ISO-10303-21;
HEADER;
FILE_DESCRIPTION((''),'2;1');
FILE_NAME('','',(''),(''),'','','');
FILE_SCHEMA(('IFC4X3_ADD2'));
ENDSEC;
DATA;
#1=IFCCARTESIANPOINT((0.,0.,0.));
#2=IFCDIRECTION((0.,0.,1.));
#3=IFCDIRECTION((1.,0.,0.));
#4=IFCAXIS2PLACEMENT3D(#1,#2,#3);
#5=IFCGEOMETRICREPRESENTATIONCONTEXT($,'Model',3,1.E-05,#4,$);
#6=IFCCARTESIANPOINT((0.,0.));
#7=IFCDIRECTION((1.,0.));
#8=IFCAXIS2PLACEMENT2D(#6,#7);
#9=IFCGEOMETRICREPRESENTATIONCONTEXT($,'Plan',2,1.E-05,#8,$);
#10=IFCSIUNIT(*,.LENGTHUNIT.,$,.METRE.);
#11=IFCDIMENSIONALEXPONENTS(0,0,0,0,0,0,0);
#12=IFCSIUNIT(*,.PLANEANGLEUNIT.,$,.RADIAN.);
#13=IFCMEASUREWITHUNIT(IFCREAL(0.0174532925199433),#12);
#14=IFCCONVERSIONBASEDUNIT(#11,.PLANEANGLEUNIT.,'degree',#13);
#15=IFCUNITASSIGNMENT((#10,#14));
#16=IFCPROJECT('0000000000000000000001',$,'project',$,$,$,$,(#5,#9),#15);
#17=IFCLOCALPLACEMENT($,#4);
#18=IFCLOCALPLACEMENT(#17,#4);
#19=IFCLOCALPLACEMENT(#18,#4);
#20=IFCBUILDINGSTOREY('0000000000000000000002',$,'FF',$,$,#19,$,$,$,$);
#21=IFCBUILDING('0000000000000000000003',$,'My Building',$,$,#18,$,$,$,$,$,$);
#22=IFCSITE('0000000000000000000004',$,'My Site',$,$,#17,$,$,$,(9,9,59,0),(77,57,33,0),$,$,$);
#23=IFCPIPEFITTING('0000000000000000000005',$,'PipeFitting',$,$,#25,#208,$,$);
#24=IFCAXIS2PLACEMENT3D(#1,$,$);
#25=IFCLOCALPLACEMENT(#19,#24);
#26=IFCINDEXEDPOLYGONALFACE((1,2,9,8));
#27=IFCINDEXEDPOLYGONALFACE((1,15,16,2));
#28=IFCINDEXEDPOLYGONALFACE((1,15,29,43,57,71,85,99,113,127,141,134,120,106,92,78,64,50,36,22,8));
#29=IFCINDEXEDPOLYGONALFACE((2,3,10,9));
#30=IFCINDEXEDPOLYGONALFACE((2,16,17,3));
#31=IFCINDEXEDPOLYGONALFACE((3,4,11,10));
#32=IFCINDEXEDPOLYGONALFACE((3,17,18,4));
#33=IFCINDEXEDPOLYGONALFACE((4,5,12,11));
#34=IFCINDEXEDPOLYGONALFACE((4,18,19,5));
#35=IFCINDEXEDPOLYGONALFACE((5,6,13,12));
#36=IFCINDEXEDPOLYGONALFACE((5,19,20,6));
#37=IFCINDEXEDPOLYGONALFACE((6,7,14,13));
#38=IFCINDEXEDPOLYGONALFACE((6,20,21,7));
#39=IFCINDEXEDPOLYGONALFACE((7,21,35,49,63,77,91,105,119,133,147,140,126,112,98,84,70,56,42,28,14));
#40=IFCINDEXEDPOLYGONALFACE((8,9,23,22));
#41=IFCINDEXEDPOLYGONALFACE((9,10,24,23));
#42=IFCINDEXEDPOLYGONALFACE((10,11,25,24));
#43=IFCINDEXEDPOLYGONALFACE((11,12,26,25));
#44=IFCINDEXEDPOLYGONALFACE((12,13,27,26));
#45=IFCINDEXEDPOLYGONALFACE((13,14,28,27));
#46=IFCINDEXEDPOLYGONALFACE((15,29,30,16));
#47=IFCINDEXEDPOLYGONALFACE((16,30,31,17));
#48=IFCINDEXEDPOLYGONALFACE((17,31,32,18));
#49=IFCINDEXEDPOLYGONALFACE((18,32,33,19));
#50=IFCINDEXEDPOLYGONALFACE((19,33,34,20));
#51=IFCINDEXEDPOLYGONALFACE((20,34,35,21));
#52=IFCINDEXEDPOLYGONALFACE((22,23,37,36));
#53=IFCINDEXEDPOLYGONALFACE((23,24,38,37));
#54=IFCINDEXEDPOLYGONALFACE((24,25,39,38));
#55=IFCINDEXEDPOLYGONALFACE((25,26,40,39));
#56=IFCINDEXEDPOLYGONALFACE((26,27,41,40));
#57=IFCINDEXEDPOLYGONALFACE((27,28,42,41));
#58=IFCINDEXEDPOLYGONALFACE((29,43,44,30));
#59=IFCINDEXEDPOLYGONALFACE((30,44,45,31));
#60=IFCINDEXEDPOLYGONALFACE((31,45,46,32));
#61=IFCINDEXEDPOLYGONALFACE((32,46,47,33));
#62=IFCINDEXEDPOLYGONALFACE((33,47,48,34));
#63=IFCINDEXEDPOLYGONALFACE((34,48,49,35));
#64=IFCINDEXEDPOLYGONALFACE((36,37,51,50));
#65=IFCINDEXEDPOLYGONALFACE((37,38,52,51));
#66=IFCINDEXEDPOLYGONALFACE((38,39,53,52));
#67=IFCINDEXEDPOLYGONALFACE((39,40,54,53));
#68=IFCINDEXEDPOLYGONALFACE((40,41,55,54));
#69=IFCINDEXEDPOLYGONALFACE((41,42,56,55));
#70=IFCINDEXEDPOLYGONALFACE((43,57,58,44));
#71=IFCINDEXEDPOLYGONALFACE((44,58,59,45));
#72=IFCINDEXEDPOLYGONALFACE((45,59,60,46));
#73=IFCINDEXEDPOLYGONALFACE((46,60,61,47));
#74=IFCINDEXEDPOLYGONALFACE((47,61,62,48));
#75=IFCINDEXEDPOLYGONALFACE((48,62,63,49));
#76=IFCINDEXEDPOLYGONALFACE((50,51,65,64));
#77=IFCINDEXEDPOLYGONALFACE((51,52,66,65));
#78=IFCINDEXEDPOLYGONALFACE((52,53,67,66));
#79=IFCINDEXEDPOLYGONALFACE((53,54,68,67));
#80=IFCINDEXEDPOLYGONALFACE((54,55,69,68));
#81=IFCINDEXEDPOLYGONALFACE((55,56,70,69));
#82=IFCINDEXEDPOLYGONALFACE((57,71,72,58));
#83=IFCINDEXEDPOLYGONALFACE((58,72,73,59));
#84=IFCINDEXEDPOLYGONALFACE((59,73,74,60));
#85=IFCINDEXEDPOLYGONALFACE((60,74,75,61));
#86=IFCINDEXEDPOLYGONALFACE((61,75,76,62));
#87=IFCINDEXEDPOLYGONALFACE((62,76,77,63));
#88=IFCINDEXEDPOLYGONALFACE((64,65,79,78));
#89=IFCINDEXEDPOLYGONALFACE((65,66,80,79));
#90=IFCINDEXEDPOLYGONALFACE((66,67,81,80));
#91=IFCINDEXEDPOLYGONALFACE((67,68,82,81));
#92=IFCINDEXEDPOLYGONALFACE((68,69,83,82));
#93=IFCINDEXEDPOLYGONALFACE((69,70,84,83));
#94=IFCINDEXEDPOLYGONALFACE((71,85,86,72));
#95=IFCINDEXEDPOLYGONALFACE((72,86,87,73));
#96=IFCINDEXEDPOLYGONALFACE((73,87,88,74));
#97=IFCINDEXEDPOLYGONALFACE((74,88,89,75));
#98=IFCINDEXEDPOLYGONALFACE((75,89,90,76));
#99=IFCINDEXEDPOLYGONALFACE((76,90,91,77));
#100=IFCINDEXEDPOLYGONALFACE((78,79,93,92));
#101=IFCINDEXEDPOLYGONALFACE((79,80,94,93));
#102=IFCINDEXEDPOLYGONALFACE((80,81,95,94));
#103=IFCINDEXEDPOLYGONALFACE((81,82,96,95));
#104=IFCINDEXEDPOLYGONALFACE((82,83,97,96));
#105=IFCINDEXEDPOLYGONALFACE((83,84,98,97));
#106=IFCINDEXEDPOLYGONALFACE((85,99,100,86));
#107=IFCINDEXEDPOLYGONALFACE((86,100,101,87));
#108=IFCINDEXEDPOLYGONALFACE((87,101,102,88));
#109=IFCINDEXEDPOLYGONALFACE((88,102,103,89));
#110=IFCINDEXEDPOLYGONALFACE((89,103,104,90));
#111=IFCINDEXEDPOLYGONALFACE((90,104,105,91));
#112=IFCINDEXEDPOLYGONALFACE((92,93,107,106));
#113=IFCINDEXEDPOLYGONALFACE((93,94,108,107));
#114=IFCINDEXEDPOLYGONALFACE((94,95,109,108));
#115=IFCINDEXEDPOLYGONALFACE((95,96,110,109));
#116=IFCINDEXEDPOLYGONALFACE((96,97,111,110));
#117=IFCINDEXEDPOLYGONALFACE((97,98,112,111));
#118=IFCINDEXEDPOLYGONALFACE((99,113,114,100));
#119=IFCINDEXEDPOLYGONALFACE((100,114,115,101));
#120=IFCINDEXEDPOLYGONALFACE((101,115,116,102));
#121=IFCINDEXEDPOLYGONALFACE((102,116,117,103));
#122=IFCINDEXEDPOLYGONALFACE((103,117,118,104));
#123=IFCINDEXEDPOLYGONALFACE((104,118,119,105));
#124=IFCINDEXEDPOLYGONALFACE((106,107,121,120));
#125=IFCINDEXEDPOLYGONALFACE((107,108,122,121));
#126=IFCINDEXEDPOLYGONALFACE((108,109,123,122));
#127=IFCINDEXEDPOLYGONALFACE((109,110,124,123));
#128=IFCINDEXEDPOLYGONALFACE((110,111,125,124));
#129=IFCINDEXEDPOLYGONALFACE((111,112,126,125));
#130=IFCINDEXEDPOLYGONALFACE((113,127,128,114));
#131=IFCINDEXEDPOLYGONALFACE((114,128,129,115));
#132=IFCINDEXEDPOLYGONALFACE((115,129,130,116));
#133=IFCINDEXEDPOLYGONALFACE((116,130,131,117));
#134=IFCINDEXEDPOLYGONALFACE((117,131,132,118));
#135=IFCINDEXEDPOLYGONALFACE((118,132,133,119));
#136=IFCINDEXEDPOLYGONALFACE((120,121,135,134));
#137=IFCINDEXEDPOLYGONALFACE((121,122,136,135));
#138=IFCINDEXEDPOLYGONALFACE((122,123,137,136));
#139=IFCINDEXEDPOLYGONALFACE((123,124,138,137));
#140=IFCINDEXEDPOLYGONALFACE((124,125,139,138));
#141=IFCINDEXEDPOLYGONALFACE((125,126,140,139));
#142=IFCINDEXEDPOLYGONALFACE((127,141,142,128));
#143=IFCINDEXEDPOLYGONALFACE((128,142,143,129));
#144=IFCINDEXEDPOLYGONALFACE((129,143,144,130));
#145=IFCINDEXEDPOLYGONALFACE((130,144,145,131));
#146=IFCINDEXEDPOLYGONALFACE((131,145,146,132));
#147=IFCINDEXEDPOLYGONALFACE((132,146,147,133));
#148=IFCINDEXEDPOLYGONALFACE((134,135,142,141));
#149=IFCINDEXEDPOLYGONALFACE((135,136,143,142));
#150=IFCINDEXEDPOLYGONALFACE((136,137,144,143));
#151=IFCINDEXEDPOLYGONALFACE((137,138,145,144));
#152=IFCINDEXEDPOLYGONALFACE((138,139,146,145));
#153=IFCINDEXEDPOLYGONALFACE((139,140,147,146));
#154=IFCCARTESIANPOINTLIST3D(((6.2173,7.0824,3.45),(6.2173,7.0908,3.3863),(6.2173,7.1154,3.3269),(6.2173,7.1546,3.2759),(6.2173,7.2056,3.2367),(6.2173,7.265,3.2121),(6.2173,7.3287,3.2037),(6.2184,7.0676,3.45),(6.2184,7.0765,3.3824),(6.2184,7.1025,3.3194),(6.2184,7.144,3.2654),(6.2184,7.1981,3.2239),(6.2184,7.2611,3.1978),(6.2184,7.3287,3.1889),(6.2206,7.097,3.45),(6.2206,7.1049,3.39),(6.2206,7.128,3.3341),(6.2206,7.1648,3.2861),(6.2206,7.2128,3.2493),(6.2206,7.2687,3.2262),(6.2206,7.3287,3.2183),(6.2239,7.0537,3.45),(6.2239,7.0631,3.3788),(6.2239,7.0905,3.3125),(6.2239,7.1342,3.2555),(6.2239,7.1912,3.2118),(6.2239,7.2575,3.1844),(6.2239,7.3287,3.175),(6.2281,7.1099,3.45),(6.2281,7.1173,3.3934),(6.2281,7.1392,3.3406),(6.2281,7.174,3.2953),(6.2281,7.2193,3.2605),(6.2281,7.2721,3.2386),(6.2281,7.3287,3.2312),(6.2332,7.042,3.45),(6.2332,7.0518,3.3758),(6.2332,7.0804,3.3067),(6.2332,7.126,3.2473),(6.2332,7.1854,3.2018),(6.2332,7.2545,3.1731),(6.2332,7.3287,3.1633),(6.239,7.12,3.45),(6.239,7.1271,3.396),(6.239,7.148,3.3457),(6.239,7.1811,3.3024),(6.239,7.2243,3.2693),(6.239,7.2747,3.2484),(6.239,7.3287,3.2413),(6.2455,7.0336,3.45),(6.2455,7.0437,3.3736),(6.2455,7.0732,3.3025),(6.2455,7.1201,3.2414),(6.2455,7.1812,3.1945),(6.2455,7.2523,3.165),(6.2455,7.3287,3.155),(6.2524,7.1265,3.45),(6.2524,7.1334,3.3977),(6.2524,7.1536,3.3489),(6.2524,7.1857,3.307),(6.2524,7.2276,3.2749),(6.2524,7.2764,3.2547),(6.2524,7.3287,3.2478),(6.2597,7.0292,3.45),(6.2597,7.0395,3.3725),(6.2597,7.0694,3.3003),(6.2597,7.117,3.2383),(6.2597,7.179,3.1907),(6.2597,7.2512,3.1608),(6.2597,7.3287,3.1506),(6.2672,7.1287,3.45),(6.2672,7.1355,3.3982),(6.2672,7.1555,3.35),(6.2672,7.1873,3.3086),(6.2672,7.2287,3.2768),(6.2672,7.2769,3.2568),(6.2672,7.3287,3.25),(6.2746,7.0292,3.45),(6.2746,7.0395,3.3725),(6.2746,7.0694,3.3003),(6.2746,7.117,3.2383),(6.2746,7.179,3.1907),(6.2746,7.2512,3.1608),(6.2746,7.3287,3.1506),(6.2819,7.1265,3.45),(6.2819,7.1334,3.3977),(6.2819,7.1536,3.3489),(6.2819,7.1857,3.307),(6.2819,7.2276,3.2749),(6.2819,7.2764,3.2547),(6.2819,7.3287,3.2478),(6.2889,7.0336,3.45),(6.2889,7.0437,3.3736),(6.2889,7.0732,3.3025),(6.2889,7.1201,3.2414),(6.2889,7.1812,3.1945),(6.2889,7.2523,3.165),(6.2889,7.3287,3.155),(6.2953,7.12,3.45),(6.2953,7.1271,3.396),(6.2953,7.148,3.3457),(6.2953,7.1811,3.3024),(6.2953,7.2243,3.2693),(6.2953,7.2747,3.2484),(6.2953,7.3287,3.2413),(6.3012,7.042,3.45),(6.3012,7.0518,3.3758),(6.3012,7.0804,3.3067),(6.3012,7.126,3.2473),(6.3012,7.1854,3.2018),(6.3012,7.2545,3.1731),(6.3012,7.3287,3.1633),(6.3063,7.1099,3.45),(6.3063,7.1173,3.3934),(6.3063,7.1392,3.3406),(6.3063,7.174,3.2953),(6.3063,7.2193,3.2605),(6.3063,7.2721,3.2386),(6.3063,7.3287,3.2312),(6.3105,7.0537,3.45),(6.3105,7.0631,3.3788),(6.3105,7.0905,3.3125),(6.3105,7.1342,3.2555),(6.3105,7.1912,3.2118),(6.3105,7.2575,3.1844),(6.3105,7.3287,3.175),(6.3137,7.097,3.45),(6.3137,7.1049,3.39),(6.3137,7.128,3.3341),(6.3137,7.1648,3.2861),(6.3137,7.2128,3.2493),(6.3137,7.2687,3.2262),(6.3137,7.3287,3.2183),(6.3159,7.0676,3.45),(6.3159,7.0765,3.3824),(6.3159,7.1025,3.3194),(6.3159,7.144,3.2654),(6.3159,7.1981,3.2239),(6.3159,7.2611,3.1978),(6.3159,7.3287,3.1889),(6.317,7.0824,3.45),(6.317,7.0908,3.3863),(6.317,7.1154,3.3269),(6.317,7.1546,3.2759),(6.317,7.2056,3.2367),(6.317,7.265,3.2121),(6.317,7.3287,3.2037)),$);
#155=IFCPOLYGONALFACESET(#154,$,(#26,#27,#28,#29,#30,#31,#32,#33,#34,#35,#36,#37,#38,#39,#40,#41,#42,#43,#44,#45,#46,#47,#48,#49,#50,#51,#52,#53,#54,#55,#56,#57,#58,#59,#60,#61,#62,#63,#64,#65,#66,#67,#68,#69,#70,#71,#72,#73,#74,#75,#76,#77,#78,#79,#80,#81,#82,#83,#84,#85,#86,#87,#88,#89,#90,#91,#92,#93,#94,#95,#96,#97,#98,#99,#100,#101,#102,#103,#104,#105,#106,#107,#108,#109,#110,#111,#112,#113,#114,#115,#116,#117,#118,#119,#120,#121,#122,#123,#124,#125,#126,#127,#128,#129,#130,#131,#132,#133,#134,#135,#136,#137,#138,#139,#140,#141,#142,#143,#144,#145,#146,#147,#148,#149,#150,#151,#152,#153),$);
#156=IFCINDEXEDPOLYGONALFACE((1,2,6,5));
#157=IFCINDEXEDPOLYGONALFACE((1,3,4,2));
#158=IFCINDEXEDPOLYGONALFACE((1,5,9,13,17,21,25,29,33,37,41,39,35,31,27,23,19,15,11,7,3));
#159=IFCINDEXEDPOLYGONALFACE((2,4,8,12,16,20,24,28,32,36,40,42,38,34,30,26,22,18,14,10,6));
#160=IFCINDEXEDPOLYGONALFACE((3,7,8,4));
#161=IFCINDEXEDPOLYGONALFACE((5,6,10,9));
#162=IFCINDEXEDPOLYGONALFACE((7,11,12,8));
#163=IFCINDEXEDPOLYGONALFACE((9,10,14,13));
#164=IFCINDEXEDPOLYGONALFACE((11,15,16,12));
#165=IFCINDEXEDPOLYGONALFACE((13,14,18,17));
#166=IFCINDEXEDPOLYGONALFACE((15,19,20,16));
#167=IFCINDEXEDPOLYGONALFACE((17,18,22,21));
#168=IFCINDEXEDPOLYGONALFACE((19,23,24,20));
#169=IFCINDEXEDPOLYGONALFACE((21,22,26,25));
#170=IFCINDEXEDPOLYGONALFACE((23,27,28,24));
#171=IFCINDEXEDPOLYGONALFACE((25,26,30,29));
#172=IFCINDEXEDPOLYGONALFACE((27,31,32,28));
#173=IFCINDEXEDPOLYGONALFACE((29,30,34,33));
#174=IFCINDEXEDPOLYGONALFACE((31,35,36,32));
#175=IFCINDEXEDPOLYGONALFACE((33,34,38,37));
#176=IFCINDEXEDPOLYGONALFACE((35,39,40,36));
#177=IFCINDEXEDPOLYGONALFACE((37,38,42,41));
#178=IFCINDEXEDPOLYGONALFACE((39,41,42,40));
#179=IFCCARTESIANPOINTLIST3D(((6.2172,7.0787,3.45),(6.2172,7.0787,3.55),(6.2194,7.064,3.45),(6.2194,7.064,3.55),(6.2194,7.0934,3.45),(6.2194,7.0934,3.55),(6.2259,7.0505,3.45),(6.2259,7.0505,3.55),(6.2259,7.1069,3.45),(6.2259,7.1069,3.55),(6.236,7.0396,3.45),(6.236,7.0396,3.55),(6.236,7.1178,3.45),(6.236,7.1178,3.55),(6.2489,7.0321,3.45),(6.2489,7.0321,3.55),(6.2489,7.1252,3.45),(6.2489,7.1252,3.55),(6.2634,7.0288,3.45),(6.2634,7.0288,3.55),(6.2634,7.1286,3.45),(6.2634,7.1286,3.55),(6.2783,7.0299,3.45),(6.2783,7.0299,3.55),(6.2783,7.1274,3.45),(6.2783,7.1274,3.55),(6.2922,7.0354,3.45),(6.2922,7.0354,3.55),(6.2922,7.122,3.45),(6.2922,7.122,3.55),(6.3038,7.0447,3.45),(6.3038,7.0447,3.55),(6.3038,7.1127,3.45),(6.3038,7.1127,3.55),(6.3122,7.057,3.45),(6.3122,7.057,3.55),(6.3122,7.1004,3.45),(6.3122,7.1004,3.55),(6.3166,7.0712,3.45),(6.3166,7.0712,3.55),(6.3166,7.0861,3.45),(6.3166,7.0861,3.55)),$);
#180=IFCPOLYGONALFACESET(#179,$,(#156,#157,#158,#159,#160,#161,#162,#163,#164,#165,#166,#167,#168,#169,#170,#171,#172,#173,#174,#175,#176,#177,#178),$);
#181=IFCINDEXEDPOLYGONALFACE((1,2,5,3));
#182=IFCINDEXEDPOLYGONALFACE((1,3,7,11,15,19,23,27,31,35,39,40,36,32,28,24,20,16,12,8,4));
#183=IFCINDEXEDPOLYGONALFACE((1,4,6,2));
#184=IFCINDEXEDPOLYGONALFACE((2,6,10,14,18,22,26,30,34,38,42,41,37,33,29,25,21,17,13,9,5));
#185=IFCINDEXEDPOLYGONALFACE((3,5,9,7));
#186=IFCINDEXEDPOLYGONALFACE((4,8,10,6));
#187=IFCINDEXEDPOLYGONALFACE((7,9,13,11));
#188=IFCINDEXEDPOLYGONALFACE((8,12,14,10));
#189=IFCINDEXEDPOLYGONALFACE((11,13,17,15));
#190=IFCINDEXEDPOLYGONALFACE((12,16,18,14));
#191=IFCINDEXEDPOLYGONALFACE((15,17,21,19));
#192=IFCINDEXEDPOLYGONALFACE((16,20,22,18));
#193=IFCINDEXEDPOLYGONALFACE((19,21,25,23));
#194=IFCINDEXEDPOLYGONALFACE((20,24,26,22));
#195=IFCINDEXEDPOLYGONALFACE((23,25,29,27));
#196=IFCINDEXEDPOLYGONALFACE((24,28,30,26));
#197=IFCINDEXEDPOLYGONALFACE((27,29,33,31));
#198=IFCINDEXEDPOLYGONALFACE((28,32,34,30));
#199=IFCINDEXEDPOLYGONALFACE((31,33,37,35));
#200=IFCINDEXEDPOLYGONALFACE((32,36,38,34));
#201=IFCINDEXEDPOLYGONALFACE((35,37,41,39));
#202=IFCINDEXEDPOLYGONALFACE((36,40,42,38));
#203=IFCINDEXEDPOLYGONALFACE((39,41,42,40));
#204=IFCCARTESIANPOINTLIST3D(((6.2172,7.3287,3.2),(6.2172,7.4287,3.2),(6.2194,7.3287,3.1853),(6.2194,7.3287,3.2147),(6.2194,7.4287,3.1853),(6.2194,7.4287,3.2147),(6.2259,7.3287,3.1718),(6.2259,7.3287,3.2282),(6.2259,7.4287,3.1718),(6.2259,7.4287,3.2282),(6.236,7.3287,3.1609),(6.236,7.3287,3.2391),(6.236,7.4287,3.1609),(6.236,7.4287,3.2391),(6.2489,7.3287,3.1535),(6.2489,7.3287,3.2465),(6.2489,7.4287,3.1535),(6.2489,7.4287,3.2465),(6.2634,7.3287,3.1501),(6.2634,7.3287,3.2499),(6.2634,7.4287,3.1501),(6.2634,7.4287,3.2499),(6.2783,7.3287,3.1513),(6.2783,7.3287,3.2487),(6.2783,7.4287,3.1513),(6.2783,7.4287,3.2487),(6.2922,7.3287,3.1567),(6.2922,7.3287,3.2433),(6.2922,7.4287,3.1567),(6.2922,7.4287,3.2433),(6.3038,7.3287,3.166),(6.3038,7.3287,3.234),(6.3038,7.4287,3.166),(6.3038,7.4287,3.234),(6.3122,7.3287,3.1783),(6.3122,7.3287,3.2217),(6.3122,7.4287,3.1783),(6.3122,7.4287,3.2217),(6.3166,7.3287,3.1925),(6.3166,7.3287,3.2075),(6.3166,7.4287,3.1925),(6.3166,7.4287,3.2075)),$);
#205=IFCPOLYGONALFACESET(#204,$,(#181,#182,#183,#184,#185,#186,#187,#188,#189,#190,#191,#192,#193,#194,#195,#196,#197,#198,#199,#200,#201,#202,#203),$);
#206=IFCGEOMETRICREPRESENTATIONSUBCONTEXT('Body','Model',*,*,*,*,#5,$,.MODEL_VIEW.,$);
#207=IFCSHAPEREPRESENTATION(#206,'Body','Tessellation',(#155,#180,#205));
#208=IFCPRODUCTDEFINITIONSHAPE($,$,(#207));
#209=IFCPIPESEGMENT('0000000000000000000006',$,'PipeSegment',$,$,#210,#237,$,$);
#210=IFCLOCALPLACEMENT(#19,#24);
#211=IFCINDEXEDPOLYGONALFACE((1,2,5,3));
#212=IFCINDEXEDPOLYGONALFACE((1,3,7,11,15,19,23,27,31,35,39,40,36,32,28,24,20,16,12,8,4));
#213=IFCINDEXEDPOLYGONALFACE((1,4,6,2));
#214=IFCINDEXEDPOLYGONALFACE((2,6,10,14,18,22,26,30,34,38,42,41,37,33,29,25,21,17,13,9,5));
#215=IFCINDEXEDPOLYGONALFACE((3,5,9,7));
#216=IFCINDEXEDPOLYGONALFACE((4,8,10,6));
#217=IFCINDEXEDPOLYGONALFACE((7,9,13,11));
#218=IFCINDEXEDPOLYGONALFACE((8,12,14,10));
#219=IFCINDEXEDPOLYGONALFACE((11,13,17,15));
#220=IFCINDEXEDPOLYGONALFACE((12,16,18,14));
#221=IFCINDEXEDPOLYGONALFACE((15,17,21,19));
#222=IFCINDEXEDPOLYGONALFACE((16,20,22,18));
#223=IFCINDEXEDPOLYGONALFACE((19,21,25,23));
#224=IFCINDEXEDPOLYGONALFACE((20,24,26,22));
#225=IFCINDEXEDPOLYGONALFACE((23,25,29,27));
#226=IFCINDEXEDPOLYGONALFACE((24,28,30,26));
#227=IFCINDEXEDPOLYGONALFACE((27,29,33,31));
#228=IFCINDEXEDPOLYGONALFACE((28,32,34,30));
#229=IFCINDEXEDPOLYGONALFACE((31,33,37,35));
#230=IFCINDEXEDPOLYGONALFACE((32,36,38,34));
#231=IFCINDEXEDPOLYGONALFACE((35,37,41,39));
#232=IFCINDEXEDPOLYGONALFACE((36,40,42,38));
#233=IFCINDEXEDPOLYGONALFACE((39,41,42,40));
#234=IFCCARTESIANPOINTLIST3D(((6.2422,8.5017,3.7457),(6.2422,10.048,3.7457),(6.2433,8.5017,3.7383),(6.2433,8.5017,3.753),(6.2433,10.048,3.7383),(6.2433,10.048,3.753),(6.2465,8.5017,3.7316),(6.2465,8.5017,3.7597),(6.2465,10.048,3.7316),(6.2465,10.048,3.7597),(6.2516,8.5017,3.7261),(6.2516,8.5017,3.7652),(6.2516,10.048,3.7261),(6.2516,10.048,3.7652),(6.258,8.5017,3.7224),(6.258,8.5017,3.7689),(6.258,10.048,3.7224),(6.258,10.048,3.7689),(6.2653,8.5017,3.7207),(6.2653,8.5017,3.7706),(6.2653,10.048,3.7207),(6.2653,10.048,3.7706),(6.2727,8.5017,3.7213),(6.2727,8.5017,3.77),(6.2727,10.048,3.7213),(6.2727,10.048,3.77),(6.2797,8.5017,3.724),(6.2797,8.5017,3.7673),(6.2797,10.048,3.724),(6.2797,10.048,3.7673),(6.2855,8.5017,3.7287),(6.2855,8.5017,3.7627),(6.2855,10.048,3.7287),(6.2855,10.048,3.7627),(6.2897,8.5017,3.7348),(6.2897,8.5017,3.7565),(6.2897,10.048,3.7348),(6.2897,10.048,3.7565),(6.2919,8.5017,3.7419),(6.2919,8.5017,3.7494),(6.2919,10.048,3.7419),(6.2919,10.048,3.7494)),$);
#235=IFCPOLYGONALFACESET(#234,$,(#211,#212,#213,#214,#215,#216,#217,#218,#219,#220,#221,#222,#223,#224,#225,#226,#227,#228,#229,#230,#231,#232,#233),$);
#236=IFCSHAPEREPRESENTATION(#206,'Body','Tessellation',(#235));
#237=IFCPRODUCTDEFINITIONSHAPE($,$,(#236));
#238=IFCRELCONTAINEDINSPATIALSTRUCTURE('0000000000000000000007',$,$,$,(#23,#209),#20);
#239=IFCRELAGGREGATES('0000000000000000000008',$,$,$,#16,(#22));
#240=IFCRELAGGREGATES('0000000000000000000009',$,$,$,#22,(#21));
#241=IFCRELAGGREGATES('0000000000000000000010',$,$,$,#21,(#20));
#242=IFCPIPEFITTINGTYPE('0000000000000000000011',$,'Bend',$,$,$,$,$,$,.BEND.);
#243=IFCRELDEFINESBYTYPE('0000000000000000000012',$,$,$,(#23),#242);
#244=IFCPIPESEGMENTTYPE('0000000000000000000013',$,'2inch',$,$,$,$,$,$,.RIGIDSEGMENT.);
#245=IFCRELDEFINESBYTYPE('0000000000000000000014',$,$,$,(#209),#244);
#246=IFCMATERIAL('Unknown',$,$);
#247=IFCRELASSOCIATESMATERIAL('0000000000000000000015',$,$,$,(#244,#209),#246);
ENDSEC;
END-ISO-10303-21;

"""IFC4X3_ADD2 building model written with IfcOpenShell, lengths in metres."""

from ifc_helpers import new_model, entity, si_unit, converted_unit, frame, origin_with_axes, origin_2d_with_axis, place, context, subcontext, project, spatial, circle, extrude, source, transform, mapped, material, material_profile, profile_set, profile_usage, type_object, type_shapes, element, save


model = new_model("IFC4X3_ADD2")

# Units and contexts
model_context = context("Model", 3, precision=1e-05, world=origin_with_axes())
plan_context = context("Plan", 2, precision=1e-05, world=origin_2d_with_axis())
body_context_1 = subcontext(model_context, "Body", "Model", "MODEL_VIEW")
ifc_project = project(units=[si_unit("LENGTHUNIT", "METRE"), converted_unit("PLANEANGLEUNIT", "degree", entity("IfcReal", 0.0174532925199433), si_unit("PLANEANGLEUNIT", "RADIAN"), dimensions=[0, 0, 0, 0, 0, 0, 0])], contexts=[model_context, plan_context])

# Site, building, storey
site_placement = place(None, origin_with_axes())
site = spatial("IfcSite", under=ifc_project, at=site_placement, Name="My Site", RefLatitude=(9, 9, 59, 0), RefLongitude=(77, 57, 33, 0))
building_placement = place(site_placement, origin_with_axes())
building = spatial("IfcBuilding", under=site, at=building_placement, Name="My Building")
storey_placement = place(building_placement, origin_with_axes())
storey = spatial("IfcBuildingStorey", under=building, at=storey_placement, Name="FF")

# Shared definitions
ifc_material = material(Name="Unknown")

# Pipe fitting
pipe_fitting_type_1 = type_object("IfcPipeFittingType", Name="Bend", PredefinedType="BEND")
shared_shape_1 = source(origin_with_axes(), body_context_1, "Body", "SolidModel", [
    entity("IfcSweptDiskSolid", entity("IfcIndexedPolyCurve", entity("IfcCartesianPointList3D", [[0.0, 0.0, -0.1], [0.0, -0.0732, -0.2768], [0.0, -0.25, -0.35]]), [entity("IfcArcIndex", [1, 2, 3])]), 0.05),
    extrude(circle(Radius=0.05), origin_with_axes(), (0.0, 0.0, -1.0), 0.1),
    extrude(circle(Radius=0.05), frame((0.0, -0.25, -0.35), z_axis=(0.0, -1.0, 0.0), x_axis=(1.0, 0.0, 0.0)), (0.0, 0.0, 1.0), 0.1),
])
type_shapes(pipe_fitting_type_1, [shared_shape_1])
pipe_fitting_1_placement = place(storey_placement, frame((6.2672, 7.0787, 3.55), z_axis=(0.0, 0.0, 1.0), x_axis=(-1.0, 0.0, 0.0)))
element("IfcPipeFitting", 1, at=pipe_fitting_1_placement, inside=storey, type_object=pipe_fitting_type_1, Name="PipeFitting", context=body_context_1, shape_type="MappedRepresentation", body=[
    mapped(shared_shape_1, transform((0.0, 0.0, 0.0), x_axis=(1.0, 0.0, 0.0), y_axis=(0.0, 1.0, 0.0), z_axis=(0.0, 0.0, 1.0), scale=1.0)),
])

# Pipe segment
ifc_material_profile_1 = material_profile(ifc_material, circle(Radius=0.025))
ifc_profile_set_1 = profile_set([ifc_material_profile_1])
ifc_profile_usage_1 = profile_usage(ifc_profile_set_1)
pipe_segment_type_1 = type_object("IfcPipeSegmentType", Name="2inch", PredefinedType="RIGIDSEGMENT", material=ifc_profile_set_1)
pipe_segment_1_placement = place(storey_placement, frame((6.2672, 8.5017, 3.7457), z_axis=(0.0, 1.0, 0.0), x_axis=(-1.0, 0.0, 0.0)))
element("IfcPipeSegment", 2, at=pipe_segment_1_placement, inside=storey, type_object=pipe_segment_type_1, material=ifc_profile_usage_1, Name="PipeSegment", context=body_context_1, shape_type="SweptSolid", body=[
    extrude(circle(Radius=0.025), origin_with_axes(), (0.0, 0.0, 1.0), 1.5464),
])

save(model, "model.ifc")
